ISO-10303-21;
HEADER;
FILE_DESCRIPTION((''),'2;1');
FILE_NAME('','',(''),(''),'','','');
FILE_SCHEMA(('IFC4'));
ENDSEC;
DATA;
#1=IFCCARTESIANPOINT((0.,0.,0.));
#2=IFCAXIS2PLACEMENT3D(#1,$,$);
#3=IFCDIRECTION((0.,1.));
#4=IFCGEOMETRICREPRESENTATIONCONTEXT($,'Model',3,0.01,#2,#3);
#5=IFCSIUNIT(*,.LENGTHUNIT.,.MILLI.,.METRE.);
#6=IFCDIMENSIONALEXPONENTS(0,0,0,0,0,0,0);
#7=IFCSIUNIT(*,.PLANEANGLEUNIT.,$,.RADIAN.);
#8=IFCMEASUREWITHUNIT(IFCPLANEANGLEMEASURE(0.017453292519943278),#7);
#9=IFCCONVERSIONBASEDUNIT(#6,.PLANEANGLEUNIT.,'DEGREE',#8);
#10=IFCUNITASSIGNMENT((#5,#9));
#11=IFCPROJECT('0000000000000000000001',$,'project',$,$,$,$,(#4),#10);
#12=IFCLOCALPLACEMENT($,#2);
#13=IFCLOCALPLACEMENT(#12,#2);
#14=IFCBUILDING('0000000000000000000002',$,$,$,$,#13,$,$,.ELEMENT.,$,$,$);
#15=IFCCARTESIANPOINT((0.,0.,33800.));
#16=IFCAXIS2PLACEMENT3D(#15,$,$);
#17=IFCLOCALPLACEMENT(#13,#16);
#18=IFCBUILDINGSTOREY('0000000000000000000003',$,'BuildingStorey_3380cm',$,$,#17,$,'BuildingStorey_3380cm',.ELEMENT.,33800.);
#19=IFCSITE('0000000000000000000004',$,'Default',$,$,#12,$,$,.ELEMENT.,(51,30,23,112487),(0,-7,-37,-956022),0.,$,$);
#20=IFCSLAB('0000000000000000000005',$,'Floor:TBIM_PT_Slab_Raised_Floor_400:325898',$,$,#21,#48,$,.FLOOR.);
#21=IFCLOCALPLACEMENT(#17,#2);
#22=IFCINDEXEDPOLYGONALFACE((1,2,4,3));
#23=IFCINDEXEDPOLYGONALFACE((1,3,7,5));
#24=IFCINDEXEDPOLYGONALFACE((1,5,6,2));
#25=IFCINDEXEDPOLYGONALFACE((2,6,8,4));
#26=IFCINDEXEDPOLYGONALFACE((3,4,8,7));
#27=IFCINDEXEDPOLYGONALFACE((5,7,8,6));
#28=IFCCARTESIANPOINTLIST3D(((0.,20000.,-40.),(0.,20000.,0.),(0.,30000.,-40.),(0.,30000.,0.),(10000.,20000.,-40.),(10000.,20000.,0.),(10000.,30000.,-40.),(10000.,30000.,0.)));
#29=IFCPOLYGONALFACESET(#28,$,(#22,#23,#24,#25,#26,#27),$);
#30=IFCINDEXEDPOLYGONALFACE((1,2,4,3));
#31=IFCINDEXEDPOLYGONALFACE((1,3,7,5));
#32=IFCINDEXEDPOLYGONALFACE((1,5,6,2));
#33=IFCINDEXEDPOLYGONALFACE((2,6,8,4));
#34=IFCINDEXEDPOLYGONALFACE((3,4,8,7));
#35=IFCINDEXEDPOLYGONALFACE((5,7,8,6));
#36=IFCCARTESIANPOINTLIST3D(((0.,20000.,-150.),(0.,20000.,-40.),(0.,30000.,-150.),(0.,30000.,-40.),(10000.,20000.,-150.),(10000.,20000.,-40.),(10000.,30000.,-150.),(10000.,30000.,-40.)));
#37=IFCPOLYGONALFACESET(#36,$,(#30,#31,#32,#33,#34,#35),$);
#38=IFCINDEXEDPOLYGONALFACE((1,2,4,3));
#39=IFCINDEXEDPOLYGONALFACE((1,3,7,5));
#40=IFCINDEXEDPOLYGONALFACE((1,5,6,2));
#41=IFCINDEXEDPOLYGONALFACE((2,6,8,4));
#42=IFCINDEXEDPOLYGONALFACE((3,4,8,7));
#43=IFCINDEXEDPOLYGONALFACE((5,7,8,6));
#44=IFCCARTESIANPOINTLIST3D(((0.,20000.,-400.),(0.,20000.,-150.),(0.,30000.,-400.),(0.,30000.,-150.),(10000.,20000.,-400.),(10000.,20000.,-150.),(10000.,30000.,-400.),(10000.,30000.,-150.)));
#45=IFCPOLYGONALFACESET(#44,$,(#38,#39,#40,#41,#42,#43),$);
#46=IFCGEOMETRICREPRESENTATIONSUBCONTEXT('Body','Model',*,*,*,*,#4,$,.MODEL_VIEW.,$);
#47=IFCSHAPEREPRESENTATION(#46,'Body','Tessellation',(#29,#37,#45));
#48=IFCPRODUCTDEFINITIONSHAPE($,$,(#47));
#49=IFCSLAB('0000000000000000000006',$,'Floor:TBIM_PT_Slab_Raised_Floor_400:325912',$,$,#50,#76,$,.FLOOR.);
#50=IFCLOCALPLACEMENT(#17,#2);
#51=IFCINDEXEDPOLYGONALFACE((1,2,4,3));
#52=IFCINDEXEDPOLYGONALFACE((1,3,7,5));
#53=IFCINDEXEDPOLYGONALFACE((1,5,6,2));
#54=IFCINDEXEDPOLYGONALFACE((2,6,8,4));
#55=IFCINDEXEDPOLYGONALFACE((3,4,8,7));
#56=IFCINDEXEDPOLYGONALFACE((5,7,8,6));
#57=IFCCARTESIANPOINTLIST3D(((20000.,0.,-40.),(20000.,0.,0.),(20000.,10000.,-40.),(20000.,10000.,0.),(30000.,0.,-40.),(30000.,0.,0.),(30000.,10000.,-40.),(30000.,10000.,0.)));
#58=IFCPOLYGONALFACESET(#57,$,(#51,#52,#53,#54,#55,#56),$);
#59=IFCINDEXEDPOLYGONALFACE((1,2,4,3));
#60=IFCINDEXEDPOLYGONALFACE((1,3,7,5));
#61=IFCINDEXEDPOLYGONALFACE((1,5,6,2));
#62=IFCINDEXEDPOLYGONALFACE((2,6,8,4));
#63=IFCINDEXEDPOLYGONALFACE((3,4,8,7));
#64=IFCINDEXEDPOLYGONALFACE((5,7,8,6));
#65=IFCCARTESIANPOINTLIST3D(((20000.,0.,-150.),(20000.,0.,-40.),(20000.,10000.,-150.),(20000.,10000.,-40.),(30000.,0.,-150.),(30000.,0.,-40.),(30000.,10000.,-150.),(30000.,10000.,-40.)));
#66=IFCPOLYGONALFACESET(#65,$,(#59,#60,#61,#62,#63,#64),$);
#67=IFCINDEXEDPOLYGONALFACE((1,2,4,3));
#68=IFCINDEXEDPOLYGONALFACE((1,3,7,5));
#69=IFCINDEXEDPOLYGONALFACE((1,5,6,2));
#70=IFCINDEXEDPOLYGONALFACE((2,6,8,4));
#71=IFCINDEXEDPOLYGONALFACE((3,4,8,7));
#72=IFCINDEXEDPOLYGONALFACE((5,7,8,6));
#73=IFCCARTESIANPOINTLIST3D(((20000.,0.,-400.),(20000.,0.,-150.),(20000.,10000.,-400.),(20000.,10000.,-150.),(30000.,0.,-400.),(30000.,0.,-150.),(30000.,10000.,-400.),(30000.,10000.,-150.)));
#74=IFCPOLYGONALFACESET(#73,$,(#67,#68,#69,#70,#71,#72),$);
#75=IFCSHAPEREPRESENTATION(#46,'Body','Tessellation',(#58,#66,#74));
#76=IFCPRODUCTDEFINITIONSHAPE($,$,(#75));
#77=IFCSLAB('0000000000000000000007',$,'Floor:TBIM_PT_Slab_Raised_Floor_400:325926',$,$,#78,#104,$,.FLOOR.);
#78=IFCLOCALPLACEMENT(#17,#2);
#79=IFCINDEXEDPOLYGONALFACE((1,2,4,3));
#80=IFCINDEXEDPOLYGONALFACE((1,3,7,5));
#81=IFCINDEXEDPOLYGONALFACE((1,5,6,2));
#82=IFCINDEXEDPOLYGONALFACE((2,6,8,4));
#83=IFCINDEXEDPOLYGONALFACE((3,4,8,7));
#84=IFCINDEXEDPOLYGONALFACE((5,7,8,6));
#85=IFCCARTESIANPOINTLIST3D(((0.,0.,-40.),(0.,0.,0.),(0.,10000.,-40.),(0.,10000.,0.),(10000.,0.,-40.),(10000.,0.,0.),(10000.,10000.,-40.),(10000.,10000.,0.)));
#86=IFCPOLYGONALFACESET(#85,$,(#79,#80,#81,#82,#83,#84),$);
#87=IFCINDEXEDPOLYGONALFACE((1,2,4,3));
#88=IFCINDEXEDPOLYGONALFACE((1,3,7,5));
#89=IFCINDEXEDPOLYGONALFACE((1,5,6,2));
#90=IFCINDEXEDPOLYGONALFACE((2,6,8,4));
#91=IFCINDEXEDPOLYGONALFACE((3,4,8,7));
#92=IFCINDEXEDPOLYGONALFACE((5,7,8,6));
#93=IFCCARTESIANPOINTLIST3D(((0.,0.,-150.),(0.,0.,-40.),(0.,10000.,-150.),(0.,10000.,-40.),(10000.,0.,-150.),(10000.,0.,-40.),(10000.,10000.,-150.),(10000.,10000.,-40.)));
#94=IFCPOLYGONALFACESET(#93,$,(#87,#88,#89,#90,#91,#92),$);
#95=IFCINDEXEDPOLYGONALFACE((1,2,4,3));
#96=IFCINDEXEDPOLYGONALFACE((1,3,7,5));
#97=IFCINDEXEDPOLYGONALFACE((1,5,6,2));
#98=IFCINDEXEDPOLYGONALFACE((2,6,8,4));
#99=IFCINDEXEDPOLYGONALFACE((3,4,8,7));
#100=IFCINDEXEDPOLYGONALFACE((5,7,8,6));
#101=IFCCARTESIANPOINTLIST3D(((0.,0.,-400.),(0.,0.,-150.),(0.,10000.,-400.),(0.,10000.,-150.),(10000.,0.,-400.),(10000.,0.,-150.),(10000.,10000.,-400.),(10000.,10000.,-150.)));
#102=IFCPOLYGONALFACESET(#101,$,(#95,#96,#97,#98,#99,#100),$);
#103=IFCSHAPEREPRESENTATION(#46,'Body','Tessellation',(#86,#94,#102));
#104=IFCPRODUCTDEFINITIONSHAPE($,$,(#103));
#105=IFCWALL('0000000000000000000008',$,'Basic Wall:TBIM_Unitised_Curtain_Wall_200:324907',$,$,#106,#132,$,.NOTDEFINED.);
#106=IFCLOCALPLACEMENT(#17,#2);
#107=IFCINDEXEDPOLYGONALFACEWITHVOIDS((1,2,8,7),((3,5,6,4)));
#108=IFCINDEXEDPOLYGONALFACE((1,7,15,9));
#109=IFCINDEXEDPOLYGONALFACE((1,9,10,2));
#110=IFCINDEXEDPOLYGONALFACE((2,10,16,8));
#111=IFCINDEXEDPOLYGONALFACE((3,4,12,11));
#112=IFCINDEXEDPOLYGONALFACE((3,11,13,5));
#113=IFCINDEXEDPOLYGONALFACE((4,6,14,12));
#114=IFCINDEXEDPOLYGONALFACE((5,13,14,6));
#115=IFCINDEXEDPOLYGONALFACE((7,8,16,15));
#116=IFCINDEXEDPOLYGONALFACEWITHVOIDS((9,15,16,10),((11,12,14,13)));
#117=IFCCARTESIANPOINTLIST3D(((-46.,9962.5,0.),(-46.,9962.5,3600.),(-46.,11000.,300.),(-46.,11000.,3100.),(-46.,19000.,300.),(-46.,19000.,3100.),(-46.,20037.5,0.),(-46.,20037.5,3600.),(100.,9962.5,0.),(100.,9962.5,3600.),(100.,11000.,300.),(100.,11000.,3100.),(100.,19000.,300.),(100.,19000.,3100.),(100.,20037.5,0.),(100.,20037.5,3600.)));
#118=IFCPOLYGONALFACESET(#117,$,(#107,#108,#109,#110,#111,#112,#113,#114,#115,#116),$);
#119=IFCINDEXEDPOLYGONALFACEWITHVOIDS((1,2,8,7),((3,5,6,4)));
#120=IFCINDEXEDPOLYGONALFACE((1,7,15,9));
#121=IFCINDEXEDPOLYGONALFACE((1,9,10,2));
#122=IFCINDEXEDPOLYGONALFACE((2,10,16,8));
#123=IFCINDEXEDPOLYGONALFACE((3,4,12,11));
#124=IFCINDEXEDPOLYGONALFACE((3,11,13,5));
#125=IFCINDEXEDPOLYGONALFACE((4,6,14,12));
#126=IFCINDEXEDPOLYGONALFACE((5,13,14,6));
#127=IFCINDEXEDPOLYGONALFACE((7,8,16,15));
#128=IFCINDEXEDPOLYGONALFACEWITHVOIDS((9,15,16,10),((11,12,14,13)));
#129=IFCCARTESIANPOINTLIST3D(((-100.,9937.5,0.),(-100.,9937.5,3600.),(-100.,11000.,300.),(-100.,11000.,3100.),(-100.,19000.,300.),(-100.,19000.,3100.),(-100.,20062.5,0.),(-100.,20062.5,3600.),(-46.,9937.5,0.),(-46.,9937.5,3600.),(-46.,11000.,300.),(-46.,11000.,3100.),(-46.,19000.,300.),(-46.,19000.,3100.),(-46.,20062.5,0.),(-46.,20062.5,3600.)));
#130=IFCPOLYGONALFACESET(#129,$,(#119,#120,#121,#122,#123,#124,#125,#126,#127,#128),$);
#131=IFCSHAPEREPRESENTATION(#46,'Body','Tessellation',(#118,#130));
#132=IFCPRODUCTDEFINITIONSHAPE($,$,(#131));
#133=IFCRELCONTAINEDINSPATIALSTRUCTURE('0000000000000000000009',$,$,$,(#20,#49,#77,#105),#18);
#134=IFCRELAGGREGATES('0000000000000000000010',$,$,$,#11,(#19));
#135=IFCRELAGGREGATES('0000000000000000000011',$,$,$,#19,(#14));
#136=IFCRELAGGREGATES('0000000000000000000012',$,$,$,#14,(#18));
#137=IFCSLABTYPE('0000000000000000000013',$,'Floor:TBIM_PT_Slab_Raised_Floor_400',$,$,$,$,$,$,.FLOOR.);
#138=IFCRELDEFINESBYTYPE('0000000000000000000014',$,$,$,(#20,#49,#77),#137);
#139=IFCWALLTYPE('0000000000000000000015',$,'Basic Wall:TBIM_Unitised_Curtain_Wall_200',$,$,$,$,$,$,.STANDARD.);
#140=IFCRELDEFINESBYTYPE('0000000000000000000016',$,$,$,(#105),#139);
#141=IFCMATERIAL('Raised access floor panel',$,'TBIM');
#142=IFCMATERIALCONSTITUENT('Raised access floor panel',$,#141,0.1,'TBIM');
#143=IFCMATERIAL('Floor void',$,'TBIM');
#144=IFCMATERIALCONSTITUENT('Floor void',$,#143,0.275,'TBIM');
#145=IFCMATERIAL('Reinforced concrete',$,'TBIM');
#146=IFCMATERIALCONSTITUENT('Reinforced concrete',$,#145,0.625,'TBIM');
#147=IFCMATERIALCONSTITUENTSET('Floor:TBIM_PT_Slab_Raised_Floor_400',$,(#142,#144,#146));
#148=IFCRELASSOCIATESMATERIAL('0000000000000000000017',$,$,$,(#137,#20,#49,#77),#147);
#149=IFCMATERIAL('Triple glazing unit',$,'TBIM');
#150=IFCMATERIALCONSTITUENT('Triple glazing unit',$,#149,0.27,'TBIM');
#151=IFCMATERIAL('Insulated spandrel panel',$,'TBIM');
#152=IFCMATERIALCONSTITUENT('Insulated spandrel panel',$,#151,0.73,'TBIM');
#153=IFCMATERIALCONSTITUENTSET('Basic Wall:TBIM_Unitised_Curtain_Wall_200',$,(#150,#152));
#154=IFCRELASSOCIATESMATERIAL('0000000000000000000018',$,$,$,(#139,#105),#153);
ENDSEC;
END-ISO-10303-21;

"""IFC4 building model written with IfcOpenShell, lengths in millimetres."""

from ifc_helpers import new_model, entity, si_unit, converted_unit, direction, frame, origin, place, context, subcontext, project, spatial, indexed_curve, outline, extrude, material, constituent, constituent_set, type_object, element, save


model = new_model("IFC4")

# Units and contexts
model_context = context("Model", 3, precision=0.01, world=origin(), true_north=direction((0.0, 1.0)))
body_context = subcontext(model_context, "Body", "Model", "MODEL_VIEW")
ifc_project = project(units=[si_unit("LENGTHUNIT", "METRE", prefix="MILLI"), converted_unit("PLANEANGLEUNIT", "DEGREE", entity("IfcPlaneAngleMeasure", 0.017453292519943278), si_unit("PLANEANGLEUNIT", "RADIAN"), dimensions=[0, 0, 0, 0, 0, 0, 0])], contexts=[model_context])

# Site, building, storey
site_placement = place(None, origin())
site = spatial("IfcSite", under=ifc_project, at=site_placement, Name="Default", CompositionType="ELEMENT", RefLatitude=(51, 30, 23, 112487), RefLongitude=(0, -7, -37, -956022), RefElevation=0.0)
building_placement = place(site_placement, origin())
building = spatial("IfcBuilding", under=site, at=building_placement, CompositionType="ELEMENT")
storey_placement = place(building_placement, frame((0.0, 0.0, 33800.0)))
storey = spatial("IfcBuildingStorey", under=building, at=storey_placement, Name="BuildingStorey_3380cm", LongName="BuildingStorey_3380cm", CompositionType="ELEMENT", Elevation=33800.0)

# Slabs
ifc_material_1 = material(Name="Raised access floor panel", Category="TBIM")
ifc_constituent_1 = constituent(ifc_material_1, Name="Raised access floor panel", Category="TBIM", fraction=0.1)
ifc_material_2 = material(Name="Floor void", Category="TBIM")
ifc_constituent_2 = constituent(ifc_material_2, Name="Floor void", Category="TBIM", fraction=0.275)
ifc_material_3 = material(Name="Reinforced concrete", Category="TBIM")
ifc_constituent_3 = constituent(ifc_material_3, Name="Reinforced concrete", Category="TBIM", fraction=0.625)
ifc_constituent_set_1 = constituent_set(constituents=[ifc_constituent_1, ifc_constituent_2, ifc_constituent_3], Name="Floor:TBIM_PT_Slab_Raised_Floor_400")
slab_type = type_object("IfcSlabType", Name="Floor:TBIM_PT_Slab_Raised_Floor_400", PredefinedType="FLOOR", material=ifc_constituent_set_1)
slab_1_placement = place(storey_placement, origin())
element("IfcSlab", 1, at=slab_1_placement, inside=storey, type_object=slab_type, material=ifc_constituent_set_1, Name="Floor:TBIM_PT_Slab_Raised_Floor_400:325898", PredefinedType="FLOOR", context=body_context, shape_type="SweptSolid", body=[
    extrude(outline(indexed_curve([(-5000.0, -5000.0), (5000.0, -5000.0), (5000.0, 5000.0), (-5000.0, 5000.0), (-5000.0, -5000.0)], self_intersect=False)), frame((5000.0, 25000.0, -40.0), z_axis=(0.0, 0.0, 1.0), x_axis=(-1.0, 0.0, 0.0)), (0.0, 0.0, 1.0), 40.0),
    extrude(outline(indexed_curve([(-5000.0, -5000.0), (5000.0, -5000.0), (5000.0, 5000.0), (-5000.0, 5000.0), (-5000.0, -5000.0)], self_intersect=False)), frame((5000.0, 25000.0, -150.0), z_axis=(0.0, 0.0, 1.0), x_axis=(-1.0, 0.0, 0.0)), (0.0, 0.0, 1.0), 110.0),
    extrude(outline(indexed_curve([(-5000.0, -5000.0), (5000.0, -5000.0), (5000.0, 5000.0), (-5000.0, 5000.0), (-5000.0, -5000.0)], self_intersect=False)), frame((5000.0, 25000.0, -400.0), z_axis=(0.0, 0.0, 1.0), x_axis=(-1.0, 0.0, 0.0)), (0.0, 0.0, 1.0), 250.0),
])
slab_2_placement = place(storey_placement, origin())
element("IfcSlab", 2, at=slab_2_placement, inside=storey, type_object=slab_type, material=ifc_constituent_set_1, Name="Floor:TBIM_PT_Slab_Raised_Floor_400:325912", PredefinedType="FLOOR", context=body_context, shape_type="SweptSolid", body=[
    extrude(outline(indexed_curve([(-5000.0, -5000.0), (5000.0, -5000.0), (5000.0, 5000.0), (-5000.0, 5000.0), (-5000.0, -5000.0)], self_intersect=False)), frame((25000.0, 5000.0, -40.0), z_axis=(0.0, 0.0, 1.0), x_axis=(-1.0, 0.0, 0.0)), (0.0, 0.0, 1.0), 40.0),
    extrude(outline(indexed_curve([(-5000.0, -5000.0), (5000.0, -5000.0), (5000.0, 5000.0), (-5000.0, 5000.0), (-5000.0, -5000.0)], self_intersect=False)), frame((25000.0, 5000.0, -150.0), z_axis=(0.0, 0.0, 1.0), x_axis=(-1.0, 0.0, 0.0)), (0.0, 0.0, 1.0), 110.0),
    extrude(outline(indexed_curve([(-5000.0, -5000.0), (5000.0, -5000.0), (5000.0, 5000.0), (-5000.0, 5000.0), (-5000.0, -5000.0)], self_intersect=False)), frame((25000.0, 5000.0, -400.0), z_axis=(0.0, 0.0, 1.0), x_axis=(-1.0, 0.0, 0.0)), (0.0, 0.0, 1.0), 250.0),
])
slab_3_placement = place(storey_placement, origin())
element("IfcSlab", 3, at=slab_3_placement, inside=storey, type_object=slab_type, material=ifc_constituent_set_1, Name="Floor:TBIM_PT_Slab_Raised_Floor_400:325926", PredefinedType="FLOOR", context=body_context, shape_type="SweptSolid", body=[
    extrude(outline(indexed_curve([(-5000.0, -5000.0), (5000.0, -5000.0), (5000.0, 5000.0), (-5000.0, 5000.0), (-5000.0, -5000.0)], self_intersect=False)), frame((5000.0, 5000.0, -40.0), z_axis=(0.0, 0.0, 1.0), x_axis=(-1.0, 0.0, 0.0)), (0.0, 0.0, 1.0), 40.0),
    extrude(outline(indexed_curve([(-5000.0, -5000.0), (5000.0, -5000.0), (5000.0, 5000.0), (-5000.0, 5000.0), (-5000.0, -5000.0)], self_intersect=False)), frame((5000.0, 5000.0, -150.0), z_axis=(0.0, 0.0, 1.0), x_axis=(-1.0, 0.0, 0.0)), (0.0, 0.0, 1.0), 110.0),
    extrude(outline(indexed_curve([(-5000.0, -5000.0), (5000.0, -5000.0), (5000.0, 5000.0), (-5000.0, 5000.0), (-5000.0, -5000.0)], self_intersect=False)), frame((5000.0, 5000.0, -400.0), z_axis=(0.0, 0.0, 1.0), x_axis=(-1.0, 0.0, 0.0)), (0.0, 0.0, 1.0), 250.0),
])

# Wall, opening
ifc_material_4 = material(Name="Triple glazing unit", Category="TBIM")
ifc_constituent_4 = constituent(ifc_material_4, Name="Triple glazing unit", Category="TBIM", fraction=0.27)
ifc_material_5 = material(Name="Insulated spandrel panel", Category="TBIM")
ifc_constituent_5 = constituent(ifc_material_5, Name="Insulated spandrel panel", Category="TBIM", fraction=0.73)
ifc_constituent_set_2 = constituent_set(constituents=[ifc_constituent_4, ifc_constituent_5], Name="Basic Wall:TBIM_Unitised_Curtain_Wall_200")
wall_type = type_object("IfcWallType", Name="Basic Wall:TBIM_Unitised_Curtain_Wall_200", PredefinedType="STANDARD", material=ifc_constituent_set_2)
wall_1_placement = place(storey_placement, frame((0.0, 9937.5, 0.0), z_axis=(0.0, 0.0, 1.0), x_axis=(0.0, 1.0, 0.0)))
wall_1 = element("IfcWall", 4, at=wall_1_placement, inside=storey, type_object=wall_type, material=ifc_constituent_set_2, Name="Basic Wall:TBIM_Unitised_Curtain_Wall_200:324907", PredefinedType="NOTDEFINED", context=body_context, shape_type="SweptSolid", body=[
    extrude(outline(indexed_curve([(-1800.0, -5037.5), (1800.0, -5037.5), (1800.0, 5037.5), (-1800.0, 5037.5), (-1800.0, -5037.5)], self_intersect=False), holes=[indexed_curve([(1300.0, 4000.0), (1300.0, -4000.0), (-1500.0, -4000.0), (-1500.0, 4000.0), (1300.0, 4000.0)], self_intersect=False)]), frame((5062.5, 46.0, 1800.0), z_axis=(0.0, -1.0, 0.0), x_axis=(0.0, 0.0, 1.0)), (0.0, 0.0, 1.0), 146.0),
    extrude(outline(indexed_curve([(-5062.5, -1800.0), (5062.5, -1800.0), (5062.5, 1800.0), (-5062.5, 1800.0), (-5062.5, -1800.0)], self_intersect=False), holes=[indexed_curve([(-4000.0, 1300.0), (4000.0, 1300.0), (4000.0, -1500.0), (-4000.0, -1500.0), (-4000.0, 1300.0)], self_intersect=False)]), frame((5062.5, 100.0, 1800.0), z_axis=(0.0, -1.0, 0.0), x_axis=(1.0, 0.0, 0.0)), (0.0, 0.0, 1.0), 54.0),
])
opening_1_placement = place(wall_1_placement, frame((1062.5, -100.0, 300.0)))
element("IfcOpeningElement", 5, at=opening_1_placement, cuts=wall_1, PredefinedType="OPENING", context=body_context, shape_type="SweptSolid", body=[
    extrude(outline(indexed_curve([(2800.0, 0.0), (2800.0, 8000.0), (0.0, 8000.0), (0.0, 0.0), (2800.0, 0.0)], self_intersect=False)), frame((0.0, 0.0, 0.0), z_axis=(0.0, 1.0, 0.0), x_axis=(0.0, 0.0, 1.0)), (0.0, 0.0, 1.0), 200.0),
])

save(model, "model.ifc")
